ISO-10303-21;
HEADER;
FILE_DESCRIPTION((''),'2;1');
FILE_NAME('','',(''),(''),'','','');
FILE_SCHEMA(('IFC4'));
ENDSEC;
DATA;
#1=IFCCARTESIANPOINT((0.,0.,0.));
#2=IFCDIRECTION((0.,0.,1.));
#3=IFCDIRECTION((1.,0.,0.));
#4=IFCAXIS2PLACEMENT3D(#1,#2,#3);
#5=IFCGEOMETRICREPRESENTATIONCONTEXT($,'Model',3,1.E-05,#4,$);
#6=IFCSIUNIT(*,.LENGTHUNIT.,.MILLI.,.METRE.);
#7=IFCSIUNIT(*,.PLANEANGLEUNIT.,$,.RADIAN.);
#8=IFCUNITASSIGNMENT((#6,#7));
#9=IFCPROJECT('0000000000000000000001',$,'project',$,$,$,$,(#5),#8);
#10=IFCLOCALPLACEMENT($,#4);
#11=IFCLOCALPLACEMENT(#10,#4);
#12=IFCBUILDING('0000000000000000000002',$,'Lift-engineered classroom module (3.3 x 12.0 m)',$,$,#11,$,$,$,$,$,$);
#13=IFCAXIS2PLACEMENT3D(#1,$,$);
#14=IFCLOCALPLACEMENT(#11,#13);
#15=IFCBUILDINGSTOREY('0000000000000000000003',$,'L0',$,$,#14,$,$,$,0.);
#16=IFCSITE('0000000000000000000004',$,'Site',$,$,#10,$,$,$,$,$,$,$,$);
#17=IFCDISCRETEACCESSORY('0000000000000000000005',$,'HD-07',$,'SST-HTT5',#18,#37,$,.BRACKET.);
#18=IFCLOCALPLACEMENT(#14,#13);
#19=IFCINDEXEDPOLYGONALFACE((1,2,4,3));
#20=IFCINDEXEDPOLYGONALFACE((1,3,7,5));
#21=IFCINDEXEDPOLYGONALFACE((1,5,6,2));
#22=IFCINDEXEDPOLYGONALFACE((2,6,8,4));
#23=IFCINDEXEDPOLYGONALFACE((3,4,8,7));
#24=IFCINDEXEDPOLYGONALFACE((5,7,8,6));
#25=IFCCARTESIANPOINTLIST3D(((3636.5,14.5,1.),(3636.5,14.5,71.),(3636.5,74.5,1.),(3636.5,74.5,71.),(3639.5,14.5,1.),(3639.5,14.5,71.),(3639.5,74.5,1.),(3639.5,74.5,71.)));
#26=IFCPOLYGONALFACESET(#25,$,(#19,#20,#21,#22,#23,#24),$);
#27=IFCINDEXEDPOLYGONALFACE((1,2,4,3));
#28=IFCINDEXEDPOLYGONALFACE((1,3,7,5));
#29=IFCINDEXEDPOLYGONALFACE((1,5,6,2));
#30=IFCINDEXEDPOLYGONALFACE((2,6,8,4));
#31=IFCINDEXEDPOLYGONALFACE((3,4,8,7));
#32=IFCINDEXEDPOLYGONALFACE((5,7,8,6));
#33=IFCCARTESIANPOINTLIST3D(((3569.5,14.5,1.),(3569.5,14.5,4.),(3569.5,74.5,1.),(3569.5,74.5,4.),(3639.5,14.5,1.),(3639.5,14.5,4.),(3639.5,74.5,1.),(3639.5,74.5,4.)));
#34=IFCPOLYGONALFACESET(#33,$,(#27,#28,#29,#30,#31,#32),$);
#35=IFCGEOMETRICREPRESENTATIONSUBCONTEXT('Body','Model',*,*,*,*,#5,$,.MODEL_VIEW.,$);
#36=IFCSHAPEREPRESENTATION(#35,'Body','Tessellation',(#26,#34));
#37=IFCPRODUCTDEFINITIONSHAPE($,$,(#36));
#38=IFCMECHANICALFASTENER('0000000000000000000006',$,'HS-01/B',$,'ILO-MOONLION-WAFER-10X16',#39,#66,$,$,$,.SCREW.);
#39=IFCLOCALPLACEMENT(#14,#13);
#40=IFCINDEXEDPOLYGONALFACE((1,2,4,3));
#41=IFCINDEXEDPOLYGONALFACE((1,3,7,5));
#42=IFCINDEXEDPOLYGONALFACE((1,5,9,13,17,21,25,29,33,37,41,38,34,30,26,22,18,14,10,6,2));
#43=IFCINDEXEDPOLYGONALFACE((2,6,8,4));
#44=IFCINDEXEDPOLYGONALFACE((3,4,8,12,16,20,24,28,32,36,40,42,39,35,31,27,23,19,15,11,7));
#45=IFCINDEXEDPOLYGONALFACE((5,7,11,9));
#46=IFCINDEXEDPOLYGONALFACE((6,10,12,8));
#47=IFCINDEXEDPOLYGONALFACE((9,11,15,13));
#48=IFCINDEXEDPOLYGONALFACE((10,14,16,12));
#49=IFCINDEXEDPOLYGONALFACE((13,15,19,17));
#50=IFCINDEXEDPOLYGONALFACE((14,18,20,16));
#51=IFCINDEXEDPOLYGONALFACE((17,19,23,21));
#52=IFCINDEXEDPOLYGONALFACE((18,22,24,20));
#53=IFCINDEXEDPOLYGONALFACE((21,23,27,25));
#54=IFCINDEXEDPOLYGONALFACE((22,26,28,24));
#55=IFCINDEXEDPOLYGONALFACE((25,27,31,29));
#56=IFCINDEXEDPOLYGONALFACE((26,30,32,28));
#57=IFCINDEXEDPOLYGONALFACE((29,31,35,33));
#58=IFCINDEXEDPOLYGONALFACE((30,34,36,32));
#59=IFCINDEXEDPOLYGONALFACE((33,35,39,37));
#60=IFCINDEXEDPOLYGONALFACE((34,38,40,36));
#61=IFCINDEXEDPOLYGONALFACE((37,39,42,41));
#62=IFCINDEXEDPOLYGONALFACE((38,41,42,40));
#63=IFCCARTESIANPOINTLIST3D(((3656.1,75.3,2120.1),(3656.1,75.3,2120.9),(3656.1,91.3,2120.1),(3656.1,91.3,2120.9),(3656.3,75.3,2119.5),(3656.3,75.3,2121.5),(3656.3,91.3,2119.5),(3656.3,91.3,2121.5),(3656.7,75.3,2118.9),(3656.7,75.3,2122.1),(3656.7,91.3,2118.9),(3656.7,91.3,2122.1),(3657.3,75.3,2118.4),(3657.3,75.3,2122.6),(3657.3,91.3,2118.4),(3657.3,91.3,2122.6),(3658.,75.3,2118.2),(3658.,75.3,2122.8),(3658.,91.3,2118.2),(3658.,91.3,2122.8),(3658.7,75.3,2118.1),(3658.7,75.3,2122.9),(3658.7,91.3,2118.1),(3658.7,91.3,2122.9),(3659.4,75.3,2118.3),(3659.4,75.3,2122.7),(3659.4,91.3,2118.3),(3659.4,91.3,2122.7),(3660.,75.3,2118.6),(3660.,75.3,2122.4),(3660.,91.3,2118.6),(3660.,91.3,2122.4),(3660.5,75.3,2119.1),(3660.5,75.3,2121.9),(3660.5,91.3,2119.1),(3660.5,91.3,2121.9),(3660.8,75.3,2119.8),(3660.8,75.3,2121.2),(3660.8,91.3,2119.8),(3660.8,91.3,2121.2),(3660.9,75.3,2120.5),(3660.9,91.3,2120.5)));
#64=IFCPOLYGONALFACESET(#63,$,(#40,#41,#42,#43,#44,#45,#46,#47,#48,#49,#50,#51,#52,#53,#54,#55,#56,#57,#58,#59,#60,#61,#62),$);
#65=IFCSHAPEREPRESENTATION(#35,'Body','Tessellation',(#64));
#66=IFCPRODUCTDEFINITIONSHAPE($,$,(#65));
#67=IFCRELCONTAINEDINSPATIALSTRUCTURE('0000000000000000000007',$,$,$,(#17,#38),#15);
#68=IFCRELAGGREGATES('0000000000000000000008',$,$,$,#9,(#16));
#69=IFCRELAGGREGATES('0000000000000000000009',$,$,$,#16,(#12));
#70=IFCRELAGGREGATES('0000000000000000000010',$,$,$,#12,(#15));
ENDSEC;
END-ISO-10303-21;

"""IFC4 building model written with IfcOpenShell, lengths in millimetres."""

from ifc_helpers import new_model, si_unit, frame, frame_2d, origin, origin_with_axes, origin_2d, place, context, subcontext, project, spatial, rectangle, circle, extrude, element, save


model = new_model("IFC4")

# Units and contexts
model_context = context("Model", 3, precision=1e-05, world=origin_with_axes())
body_context = subcontext(model_context, "Body", "Model", "MODEL_VIEW")
ifc_project = project(units=[si_unit("LENGTHUNIT", "METRE", prefix="MILLI"), si_unit("PLANEANGLEUNIT", "RADIAN")], contexts=[model_context])

# Site, building, storey
site_placement = place(None, origin_with_axes())
site = spatial("IfcSite", under=ifc_project, at=site_placement, Name="Site")
building_placement = place(site_placement, origin_with_axes())
building = spatial("IfcBuilding", under=site, at=building_placement, Name="Lift-engineered classroom module (3.3 x 12.0 m)")
storey_placement = place(building_placement, origin())
storey = spatial("IfcBuildingStorey", under=building, at=storey_placement, Name="L0", Elevation=0.0)

# Discrete accessory
discrete_accessory_placement = place(None, frame((3639.5, 44.5, 0.0), z_axis=(0.0, 0.0, 1.0), x_axis=(-1.0, 0.0, 0.0)))
element("IfcDiscreteAccessory", 1, at=discrete_accessory_placement, inside=storey, Name="HD-07", ObjectType="SST-HTT5", PredefinedType="BRACKET", context=body_context, shape_type="SweptSolid", body=[
    extrude(rectangle(XDim=3.0, YDim=60.0, at=frame_2d((1.5, 0.0))), frame((0.0, 0.0, 1.0), z_axis=(0.0, 0.0, 1.0), x_axis=(1.0, 0.0, 0.0)), (0.0, 0.0, 1.0), 70.0),
    extrude(rectangle(XDim=70.0, YDim=60.0, at=frame_2d((35.0, 0.0))), frame((0.0, 0.0, 1.0), z_axis=(0.0, 0.0, 1.0), x_axis=(1.0, 0.0, 0.0)), (0.0, 0.0, 1.0), 3.0),
])

# Mechanical fastener
mechanical_fastener_placement = place(None, frame((3658.5, 89.8, 2120.5), z_axis=(0.0, -1.0, 0.0), x_axis=(1.0, 0.0, 0.0)))
element("IfcMechanicalFastener", 2, at=mechanical_fastener_placement, inside=storey, Name="HS-01/B", ObjectType="ILO-MOONLION-WAFER-10X16", PredefinedType="SCREW", context=body_context, shape_type="SweptSolid", body=[
    extrude(circle(Radius=2.4, at=origin_2d()), frame((0.0, 0.0, -1.5), z_axis=(0.0, 0.0, 1.0), x_axis=(1.0, 0.0, 0.0)), (0.0, 0.0, 1.0), 16.0),
])

save(model, "model.ifc")
